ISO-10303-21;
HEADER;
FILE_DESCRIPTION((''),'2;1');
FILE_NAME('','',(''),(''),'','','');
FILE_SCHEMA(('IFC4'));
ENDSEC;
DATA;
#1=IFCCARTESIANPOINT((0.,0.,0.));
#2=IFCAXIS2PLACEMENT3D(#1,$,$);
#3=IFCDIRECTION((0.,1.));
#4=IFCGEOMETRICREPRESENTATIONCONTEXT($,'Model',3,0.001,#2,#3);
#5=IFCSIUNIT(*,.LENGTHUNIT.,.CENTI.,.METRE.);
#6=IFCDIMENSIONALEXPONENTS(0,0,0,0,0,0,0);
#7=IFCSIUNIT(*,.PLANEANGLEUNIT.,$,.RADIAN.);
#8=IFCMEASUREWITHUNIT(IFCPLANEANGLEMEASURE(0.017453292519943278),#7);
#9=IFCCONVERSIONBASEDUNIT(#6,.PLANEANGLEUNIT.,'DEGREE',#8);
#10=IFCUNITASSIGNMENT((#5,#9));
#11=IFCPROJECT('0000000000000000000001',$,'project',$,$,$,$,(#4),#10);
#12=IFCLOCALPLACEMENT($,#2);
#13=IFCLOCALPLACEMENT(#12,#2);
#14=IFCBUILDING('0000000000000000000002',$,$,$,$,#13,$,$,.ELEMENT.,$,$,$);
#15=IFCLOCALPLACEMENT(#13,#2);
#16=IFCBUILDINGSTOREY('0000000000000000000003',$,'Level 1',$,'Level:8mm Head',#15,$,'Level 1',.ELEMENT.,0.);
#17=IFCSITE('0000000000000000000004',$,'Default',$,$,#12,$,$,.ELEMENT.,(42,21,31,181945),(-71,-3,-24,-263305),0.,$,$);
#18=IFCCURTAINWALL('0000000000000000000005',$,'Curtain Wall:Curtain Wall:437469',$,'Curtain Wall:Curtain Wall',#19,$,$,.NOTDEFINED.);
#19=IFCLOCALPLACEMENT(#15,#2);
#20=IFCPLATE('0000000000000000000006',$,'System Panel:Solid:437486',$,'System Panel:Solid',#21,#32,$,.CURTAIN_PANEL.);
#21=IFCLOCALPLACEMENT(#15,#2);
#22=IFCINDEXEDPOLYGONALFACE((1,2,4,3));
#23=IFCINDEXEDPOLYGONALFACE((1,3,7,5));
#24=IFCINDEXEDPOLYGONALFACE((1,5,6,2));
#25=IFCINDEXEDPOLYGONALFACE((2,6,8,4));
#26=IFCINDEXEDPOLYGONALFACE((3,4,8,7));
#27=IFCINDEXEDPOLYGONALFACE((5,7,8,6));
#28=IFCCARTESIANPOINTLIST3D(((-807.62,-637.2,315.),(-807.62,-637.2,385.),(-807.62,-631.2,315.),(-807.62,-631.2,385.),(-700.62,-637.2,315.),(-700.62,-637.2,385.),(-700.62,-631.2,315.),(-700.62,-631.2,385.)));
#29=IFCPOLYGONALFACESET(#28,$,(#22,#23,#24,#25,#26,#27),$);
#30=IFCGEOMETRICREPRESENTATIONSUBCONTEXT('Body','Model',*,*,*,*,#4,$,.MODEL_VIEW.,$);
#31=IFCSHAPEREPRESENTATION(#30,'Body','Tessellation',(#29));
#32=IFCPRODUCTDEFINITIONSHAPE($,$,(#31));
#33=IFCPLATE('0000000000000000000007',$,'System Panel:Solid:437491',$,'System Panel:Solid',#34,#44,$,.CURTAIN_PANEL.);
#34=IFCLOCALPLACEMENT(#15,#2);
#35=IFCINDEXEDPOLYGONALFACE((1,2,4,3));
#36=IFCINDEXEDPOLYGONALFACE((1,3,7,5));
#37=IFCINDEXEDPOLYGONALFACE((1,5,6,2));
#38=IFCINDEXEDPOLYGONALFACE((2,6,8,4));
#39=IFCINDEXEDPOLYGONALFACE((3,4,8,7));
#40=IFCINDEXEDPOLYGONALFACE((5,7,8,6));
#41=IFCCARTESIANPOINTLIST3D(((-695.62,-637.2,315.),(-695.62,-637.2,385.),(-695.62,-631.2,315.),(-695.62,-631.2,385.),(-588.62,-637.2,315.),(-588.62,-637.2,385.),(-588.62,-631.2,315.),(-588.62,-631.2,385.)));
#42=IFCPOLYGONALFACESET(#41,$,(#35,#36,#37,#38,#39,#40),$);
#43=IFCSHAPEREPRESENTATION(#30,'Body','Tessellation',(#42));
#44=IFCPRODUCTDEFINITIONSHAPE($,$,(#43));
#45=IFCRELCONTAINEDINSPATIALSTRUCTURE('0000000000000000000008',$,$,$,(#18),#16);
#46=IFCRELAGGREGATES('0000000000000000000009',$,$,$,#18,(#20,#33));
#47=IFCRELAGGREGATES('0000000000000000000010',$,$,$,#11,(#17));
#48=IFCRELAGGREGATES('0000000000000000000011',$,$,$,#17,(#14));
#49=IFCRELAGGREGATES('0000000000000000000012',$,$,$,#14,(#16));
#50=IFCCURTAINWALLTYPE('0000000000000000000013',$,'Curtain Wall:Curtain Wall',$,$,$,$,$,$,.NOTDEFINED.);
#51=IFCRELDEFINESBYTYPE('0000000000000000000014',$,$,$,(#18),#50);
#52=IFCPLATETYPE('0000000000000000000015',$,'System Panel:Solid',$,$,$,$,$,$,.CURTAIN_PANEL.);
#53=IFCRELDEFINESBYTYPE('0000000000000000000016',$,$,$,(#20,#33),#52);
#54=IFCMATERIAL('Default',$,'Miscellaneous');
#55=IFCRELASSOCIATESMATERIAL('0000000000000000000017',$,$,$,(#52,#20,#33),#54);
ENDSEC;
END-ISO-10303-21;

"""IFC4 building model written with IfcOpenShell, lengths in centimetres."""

from ifc_helpers import new_model, entity, si_unit, converted_unit, direction, frame, origin, place, context, subcontext, project, spatial, indexed_curve, outline, extrude, source, transform, mapped, material, type_object, type_shapes, element, aggregate, save


model = new_model("IFC4")

# Units and contexts
model_context = context("Model", 3, precision=0.001, world=origin(), true_north=direction((0.0, 1.0)))
body_context = subcontext(model_context, "Body", "Model", "MODEL_VIEW")
ifc_project = project(units=[si_unit("LENGTHUNIT", "METRE", prefix="CENTI"), converted_unit("PLANEANGLEUNIT", "DEGREE", entity("IfcPlaneAngleMeasure", 0.017453292519943278), si_unit("PLANEANGLEUNIT", "RADIAN"), dimensions=[0, 0, 0, 0, 0, 0, 0])], contexts=[model_context])

# Site, building, storey
site_placement = place(None, origin())
site = spatial("IfcSite", under=ifc_project, at=site_placement, Name="Default", CompositionType="ELEMENT", RefLatitude=(42, 21, 31, 181945), RefLongitude=(-71, -3, -24, -263305), RefElevation=0.0)
building_placement = place(site_placement, origin())
building = spatial("IfcBuilding", under=site, at=building_placement, CompositionType="ELEMENT")
storey_placement = place(building_placement, origin())
storey = spatial("IfcBuildingStorey", under=building, at=storey_placement, Name="Level 1", ObjectType="Level:8mm Head", LongName="Level 1", CompositionType="ELEMENT", Elevation=0.0)

# Curtain wall, plates
curtain_wall_type = type_object("IfcCurtainWallType", Name="Curtain Wall:Curtain Wall", PredefinedType="NOTDEFINED")
curtain_wall_placement = place(storey_placement, origin())
curtain_wall = element("IfcCurtainWall", 1, at=curtain_wall_placement, inside=storey, type_object=curtain_wall_type, Name="Curtain Wall:Curtain Wall:437469", ObjectType="Curtain Wall:Curtain Wall", PredefinedType="NOTDEFINED")
ifc_material_1 = material(Name="Default", Category="Miscellaneous")
plate_type_1 = type_object("IfcPlateType", Name="System Panel:Solid", PredefinedType="CURTAIN_PANEL", material=ifc_material_1)
shared_shape_1 = source(origin(), body_context, "Body", "SweptSolid", [
    extrude(outline(indexed_curve([(-3.0, -53.5), (3.0, -53.5), (3.0, 53.5), (-3.0, 53.5), (-3.0, -53.5)], self_intersect=False)), frame((0.0, 1.95, 0.0), z_axis=(0.0, 0.0, 1.0), x_axis=(0.0, 1.0, 0.0)), (0.0, 0.0, 1.0), 70.0),
])
type_shapes(plate_type_1, [shared_shape_1])
plate_1_placement = place(curtain_wall_placement, frame((-754.12, -636.15, 315.0)))
plate_1 = element("IfcPlate", 2, at=plate_1_placement, type_object=plate_type_1, material=ifc_material_1, Name="System Panel:Solid:437486", ObjectType="System Panel:Solid", PredefinedType="CURTAIN_PANEL", context=body_context, shape_type="MappedRepresentation", body=[
    mapped(shared_shape_1, transform((0.0, 0.0, 0.0), scale=1.0)),
])
plate_2_placement = place(curtain_wall_placement, frame((-642.12, -636.15, 315.0)))
plate_2 = element("IfcPlate", 3, at=plate_2_placement, type_object=plate_type_1, material=ifc_material_1, Name="System Panel:Solid:437491", ObjectType="System Panel:Solid", PredefinedType="CURTAIN_PANEL", context=body_context, shape_type="MappedRepresentation", body=[
    mapped(shared_shape_1, transform((0.0, 0.0, 0.0), scale=1.0)),
])
aggregate(curtain_wall, [plate_1, plate_2])

save(model, "model.ifc")
